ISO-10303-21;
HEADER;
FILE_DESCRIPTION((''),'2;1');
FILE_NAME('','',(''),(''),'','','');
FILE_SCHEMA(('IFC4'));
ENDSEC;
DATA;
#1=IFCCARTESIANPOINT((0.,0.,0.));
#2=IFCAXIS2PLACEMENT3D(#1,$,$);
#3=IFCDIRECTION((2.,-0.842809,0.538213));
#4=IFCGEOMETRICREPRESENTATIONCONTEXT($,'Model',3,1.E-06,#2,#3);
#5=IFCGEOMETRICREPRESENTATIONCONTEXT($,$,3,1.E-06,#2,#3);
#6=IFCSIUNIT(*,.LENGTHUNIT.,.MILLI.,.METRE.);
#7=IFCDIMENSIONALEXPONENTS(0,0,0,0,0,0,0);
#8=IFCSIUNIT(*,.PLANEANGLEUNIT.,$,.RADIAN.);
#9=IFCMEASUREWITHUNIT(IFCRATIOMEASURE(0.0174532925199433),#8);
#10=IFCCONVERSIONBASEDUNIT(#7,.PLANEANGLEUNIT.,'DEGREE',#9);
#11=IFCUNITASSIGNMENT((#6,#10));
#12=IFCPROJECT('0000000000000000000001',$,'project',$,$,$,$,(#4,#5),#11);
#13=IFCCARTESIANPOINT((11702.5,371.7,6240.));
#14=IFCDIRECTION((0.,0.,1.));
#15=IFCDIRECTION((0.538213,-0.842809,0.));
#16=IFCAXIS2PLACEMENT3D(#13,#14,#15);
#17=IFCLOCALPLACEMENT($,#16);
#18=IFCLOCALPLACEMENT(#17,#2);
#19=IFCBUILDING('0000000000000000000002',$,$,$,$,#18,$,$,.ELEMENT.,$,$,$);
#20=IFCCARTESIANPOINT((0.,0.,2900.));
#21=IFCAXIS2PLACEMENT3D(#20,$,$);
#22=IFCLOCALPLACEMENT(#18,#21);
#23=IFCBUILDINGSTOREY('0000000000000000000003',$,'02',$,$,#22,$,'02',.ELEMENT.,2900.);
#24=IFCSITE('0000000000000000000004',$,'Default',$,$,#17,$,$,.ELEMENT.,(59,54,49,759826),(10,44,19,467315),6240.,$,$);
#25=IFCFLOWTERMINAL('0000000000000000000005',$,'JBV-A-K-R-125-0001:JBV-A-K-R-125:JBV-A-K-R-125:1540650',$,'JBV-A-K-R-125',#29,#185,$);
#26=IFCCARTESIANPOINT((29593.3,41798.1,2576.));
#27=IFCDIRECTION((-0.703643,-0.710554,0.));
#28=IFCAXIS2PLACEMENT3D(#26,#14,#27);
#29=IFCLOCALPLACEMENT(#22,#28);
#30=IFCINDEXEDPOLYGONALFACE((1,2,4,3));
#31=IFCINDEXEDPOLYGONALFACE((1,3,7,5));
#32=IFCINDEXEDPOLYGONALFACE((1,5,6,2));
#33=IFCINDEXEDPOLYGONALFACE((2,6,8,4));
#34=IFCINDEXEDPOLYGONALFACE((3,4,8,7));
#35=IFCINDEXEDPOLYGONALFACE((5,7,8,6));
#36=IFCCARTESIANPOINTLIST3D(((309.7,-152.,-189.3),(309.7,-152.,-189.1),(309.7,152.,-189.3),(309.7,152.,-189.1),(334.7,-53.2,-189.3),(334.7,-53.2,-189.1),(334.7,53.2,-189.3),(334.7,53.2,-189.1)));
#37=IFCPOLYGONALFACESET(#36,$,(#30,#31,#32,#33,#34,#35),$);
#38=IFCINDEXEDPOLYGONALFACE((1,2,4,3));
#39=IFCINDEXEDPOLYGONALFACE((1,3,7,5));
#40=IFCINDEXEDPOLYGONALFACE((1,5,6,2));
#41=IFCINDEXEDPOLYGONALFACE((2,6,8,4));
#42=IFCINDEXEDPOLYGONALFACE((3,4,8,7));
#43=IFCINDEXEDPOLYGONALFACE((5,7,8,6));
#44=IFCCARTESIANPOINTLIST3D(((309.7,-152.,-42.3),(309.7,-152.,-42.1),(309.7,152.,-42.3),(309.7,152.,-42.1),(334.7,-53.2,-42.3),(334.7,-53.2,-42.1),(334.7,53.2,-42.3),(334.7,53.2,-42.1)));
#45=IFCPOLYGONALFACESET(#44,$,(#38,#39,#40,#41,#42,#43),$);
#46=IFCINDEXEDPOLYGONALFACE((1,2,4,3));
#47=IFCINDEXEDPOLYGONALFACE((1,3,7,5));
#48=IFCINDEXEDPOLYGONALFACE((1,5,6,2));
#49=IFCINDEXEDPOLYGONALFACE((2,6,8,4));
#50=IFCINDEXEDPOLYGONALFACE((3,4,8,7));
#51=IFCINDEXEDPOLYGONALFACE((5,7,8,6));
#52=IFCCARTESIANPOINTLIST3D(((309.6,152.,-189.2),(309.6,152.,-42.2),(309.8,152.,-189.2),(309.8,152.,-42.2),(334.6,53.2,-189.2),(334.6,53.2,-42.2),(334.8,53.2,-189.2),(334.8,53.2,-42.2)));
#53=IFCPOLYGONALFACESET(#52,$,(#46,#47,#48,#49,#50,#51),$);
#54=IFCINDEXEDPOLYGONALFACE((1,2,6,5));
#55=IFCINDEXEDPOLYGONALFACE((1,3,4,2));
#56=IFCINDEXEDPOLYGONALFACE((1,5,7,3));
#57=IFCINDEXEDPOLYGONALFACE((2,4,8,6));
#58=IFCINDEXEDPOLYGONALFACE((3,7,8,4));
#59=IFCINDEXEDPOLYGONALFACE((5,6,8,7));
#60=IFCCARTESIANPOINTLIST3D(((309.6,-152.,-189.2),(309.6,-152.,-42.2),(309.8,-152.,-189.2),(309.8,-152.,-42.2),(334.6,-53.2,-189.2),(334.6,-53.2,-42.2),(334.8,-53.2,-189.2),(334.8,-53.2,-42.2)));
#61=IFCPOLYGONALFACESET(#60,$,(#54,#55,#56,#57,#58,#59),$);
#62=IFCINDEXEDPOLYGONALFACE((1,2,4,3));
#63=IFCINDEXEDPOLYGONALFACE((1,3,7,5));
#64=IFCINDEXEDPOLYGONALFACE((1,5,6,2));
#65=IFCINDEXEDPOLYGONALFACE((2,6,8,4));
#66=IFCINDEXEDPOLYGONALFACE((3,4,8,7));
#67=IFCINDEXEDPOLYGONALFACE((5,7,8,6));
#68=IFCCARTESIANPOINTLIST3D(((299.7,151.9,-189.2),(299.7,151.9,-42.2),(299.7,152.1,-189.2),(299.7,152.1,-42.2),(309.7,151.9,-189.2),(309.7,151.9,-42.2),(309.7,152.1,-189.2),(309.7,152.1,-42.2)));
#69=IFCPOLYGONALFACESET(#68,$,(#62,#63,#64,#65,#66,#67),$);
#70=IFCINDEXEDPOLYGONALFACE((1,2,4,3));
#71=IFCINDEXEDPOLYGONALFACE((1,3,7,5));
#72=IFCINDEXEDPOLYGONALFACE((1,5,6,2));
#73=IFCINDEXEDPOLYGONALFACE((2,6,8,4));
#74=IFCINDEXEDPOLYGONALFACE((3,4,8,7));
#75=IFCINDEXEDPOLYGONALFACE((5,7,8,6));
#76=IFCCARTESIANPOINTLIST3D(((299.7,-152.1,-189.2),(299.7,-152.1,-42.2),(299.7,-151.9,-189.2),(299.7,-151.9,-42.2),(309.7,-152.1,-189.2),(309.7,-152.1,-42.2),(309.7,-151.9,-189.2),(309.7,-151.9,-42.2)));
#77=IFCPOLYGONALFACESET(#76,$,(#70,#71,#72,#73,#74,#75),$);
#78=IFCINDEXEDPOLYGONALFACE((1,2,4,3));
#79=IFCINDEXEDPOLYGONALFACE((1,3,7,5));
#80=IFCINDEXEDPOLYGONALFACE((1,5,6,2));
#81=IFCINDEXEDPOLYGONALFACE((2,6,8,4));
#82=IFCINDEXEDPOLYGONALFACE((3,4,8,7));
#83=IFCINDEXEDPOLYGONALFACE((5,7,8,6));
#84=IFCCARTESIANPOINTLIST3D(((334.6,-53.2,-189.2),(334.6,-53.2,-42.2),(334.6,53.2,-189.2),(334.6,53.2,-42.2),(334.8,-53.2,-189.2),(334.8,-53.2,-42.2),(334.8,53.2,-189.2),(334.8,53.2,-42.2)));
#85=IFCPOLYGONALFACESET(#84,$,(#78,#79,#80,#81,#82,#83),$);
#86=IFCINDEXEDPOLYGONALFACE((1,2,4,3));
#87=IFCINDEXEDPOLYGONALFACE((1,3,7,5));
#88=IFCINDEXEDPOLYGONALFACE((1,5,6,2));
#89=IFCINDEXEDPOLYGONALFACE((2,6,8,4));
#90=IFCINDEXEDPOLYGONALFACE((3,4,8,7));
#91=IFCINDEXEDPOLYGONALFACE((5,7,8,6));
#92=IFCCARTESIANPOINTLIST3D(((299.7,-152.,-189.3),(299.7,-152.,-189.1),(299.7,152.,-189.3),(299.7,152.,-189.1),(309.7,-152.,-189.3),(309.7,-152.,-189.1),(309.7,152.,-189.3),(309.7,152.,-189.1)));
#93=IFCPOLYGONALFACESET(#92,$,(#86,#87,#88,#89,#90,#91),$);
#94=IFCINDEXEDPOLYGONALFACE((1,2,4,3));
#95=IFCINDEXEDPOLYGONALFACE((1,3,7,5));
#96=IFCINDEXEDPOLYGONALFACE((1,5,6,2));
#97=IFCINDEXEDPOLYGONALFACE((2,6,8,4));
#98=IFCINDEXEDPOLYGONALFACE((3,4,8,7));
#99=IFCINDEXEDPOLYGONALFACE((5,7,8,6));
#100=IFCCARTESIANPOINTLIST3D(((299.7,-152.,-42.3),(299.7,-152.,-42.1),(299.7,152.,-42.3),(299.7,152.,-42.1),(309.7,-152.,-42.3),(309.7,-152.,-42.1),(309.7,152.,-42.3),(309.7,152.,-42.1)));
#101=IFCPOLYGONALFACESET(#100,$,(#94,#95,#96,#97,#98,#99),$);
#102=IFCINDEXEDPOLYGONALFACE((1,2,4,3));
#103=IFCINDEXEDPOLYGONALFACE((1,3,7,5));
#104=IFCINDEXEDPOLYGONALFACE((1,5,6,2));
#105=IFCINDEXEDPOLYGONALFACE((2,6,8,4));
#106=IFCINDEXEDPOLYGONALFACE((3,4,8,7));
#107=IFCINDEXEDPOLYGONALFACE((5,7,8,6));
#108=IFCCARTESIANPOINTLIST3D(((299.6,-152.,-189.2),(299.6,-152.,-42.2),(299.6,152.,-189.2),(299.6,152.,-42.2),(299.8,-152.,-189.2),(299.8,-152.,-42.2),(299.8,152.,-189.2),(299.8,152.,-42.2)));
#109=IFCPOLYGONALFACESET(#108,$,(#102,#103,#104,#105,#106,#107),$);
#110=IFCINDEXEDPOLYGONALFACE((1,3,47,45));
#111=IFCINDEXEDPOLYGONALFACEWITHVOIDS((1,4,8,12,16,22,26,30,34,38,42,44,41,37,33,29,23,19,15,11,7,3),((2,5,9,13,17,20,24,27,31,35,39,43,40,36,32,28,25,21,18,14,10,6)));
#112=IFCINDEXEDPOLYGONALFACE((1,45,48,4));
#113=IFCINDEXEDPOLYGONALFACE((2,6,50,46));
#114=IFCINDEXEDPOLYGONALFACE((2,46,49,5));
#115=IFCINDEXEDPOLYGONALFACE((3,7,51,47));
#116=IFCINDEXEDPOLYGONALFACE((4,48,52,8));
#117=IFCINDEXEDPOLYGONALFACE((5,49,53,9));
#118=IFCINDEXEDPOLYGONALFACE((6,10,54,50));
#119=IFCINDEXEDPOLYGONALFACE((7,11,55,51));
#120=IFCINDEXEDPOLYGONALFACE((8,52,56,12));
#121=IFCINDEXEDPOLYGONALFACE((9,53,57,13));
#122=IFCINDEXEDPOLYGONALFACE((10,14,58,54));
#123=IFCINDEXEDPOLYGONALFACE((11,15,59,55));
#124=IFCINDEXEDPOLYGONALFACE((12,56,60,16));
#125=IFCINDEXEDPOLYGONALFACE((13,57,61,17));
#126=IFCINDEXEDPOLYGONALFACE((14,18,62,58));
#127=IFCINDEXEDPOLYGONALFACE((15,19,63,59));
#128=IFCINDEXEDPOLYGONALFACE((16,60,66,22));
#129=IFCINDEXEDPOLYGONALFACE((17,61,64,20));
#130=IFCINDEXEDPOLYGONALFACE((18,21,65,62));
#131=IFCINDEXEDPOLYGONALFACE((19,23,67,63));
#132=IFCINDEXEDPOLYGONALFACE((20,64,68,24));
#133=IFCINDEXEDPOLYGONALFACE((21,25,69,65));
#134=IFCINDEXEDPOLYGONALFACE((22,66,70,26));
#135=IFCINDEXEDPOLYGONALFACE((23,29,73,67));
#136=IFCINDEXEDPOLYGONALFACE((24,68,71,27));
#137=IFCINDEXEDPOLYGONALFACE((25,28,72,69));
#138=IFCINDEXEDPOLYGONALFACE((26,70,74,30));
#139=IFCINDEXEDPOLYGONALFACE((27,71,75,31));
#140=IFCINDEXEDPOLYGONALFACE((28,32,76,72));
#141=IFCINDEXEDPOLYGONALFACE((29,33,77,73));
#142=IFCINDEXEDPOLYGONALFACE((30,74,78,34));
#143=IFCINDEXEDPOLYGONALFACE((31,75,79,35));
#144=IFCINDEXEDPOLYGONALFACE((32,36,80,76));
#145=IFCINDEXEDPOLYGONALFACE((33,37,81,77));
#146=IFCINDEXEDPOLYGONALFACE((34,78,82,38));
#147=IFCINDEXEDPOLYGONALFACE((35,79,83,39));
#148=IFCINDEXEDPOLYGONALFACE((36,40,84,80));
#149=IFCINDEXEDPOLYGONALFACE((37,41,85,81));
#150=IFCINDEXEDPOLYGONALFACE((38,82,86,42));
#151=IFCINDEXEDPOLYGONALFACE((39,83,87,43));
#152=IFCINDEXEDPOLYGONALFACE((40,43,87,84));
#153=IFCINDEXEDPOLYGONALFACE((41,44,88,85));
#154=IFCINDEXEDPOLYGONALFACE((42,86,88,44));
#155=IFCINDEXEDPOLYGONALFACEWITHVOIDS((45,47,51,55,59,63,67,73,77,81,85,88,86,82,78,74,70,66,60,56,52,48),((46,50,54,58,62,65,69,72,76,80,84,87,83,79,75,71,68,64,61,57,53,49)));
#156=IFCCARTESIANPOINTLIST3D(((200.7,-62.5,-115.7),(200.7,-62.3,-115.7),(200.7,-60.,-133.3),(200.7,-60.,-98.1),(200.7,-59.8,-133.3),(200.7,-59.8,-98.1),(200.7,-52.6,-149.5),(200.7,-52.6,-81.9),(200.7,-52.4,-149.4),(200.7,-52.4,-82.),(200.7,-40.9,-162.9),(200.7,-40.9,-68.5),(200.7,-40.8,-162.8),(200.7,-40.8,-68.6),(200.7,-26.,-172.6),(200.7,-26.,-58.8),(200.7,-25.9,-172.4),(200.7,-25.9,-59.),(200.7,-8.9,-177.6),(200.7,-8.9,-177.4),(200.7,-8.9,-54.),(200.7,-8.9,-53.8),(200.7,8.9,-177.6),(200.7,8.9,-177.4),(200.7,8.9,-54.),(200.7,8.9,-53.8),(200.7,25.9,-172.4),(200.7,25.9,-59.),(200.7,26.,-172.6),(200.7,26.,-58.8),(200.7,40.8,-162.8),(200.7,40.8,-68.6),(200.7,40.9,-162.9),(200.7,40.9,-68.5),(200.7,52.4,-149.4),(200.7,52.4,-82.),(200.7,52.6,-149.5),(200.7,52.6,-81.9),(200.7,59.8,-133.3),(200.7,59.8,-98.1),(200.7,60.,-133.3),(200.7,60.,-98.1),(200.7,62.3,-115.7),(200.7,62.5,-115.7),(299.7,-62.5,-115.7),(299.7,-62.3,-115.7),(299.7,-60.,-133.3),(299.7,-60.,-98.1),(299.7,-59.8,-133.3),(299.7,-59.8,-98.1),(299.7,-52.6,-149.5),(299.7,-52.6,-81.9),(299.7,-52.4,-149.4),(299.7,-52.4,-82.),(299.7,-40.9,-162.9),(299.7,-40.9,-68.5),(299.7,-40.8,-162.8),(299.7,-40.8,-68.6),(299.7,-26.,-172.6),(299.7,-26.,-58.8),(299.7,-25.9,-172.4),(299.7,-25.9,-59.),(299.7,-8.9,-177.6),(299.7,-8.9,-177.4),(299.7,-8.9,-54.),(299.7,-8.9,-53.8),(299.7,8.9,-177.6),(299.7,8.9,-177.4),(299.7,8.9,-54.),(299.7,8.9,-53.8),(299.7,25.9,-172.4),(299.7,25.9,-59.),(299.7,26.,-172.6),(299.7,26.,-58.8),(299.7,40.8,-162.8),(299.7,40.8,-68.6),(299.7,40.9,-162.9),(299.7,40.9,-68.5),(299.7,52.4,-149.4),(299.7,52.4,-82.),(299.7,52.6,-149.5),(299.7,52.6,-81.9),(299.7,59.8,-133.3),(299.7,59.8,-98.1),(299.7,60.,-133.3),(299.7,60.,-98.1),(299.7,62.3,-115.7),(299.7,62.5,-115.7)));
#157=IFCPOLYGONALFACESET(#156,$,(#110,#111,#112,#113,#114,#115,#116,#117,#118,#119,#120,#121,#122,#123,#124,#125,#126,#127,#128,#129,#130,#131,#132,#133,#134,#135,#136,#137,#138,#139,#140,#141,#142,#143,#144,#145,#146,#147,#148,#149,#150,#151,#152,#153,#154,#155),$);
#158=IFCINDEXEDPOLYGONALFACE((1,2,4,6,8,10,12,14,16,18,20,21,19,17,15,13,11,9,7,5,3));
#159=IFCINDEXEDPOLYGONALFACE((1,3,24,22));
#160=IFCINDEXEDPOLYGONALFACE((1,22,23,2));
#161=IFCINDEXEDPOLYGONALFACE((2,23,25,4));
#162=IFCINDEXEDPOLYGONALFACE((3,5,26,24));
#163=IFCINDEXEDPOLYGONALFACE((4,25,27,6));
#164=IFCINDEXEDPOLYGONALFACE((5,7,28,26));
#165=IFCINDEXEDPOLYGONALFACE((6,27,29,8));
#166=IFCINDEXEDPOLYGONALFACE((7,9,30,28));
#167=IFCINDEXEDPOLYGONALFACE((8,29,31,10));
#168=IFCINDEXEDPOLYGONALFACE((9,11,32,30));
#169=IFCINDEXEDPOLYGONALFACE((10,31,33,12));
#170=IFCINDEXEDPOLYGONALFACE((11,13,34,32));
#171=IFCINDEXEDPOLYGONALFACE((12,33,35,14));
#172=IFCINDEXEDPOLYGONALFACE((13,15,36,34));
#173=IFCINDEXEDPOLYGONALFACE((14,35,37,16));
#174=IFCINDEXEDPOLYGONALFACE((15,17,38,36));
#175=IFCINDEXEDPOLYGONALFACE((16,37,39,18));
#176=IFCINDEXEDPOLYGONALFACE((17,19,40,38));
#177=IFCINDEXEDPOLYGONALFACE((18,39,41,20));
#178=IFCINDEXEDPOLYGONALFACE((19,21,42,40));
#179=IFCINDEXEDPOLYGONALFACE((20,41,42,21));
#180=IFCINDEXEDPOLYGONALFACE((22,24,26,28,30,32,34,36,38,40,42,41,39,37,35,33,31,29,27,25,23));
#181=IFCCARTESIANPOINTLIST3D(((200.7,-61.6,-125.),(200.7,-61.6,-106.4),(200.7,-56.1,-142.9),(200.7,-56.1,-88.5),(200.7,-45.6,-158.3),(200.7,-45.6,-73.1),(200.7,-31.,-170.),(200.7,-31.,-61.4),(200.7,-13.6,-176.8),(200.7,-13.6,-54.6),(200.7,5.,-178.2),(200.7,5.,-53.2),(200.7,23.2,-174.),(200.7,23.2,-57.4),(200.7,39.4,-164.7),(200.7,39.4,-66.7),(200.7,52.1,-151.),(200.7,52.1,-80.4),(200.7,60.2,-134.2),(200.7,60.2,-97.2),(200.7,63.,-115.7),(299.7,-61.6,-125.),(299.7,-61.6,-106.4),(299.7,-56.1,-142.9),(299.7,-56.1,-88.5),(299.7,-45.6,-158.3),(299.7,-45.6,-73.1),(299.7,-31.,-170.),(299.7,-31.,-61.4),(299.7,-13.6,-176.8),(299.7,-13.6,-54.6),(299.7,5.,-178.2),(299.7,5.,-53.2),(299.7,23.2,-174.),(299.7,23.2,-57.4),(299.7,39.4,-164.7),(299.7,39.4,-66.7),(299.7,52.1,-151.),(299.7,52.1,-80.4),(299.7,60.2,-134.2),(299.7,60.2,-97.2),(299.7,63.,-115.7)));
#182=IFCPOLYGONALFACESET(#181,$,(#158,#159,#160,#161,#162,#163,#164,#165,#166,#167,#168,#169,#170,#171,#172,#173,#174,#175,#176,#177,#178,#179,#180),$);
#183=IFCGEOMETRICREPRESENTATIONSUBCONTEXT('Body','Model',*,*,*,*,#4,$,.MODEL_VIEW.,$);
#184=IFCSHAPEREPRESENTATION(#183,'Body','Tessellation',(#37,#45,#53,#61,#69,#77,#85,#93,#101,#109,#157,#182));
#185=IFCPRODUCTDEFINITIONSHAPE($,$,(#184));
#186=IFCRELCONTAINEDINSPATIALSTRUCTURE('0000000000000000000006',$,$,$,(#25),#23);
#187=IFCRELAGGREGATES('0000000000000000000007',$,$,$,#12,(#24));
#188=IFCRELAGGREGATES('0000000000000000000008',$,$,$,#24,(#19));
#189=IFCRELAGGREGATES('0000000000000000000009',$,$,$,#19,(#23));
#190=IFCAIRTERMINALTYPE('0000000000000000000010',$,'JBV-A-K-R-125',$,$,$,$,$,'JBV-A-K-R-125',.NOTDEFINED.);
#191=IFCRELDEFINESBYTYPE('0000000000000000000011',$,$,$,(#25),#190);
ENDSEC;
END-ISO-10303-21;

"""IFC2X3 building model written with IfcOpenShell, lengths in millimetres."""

from ifc_helpers import new_model, entity, si_unit, converted_unit, direction, frame, frame_2d, origin, origin_2d_with_axis, place, context, subcontext, project, spatial, polyline, circle_curve, parameter, trimmed, segment, composite_curve, rectangle, circle, outline, extrude, source, transform, mapped, type_object, type_shapes, element, save


model = new_model("IFC2X3")

# Units and contexts
model_context = context("Model", 3, precision=1e-06, world=origin(), true_north=direction((2.0, -0.842809, 0.538213)))
context_of_model = context(None, 3, precision=1e-06, world=origin(), true_north=direction((2.0, -0.842809, 0.538213)))
body_context = subcontext(model_context, "Body", "Model", "MODEL_VIEW")
ifc_project = project(units=[si_unit("LENGTHUNIT", "METRE", prefix="MILLI"), converted_unit("PLANEANGLEUNIT", "DEGREE", entity("IfcRatioMeasure", 0.0174532925199433), si_unit("PLANEANGLEUNIT", "RADIAN"), dimensions=[0, 0, 0, 0, 0, 0, 0])], contexts=[model_context, context_of_model])

# Site, building, storey
site_placement = place(None, frame((11702.5, 371.7, 6240.0), z_axis=(0.0, 0.0, 1.0), x_axis=(0.538213, -0.842809, 0.0)))
site = spatial("IfcSite", under=ifc_project, at=site_placement, Name="Default", CompositionType="ELEMENT", RefLatitude=(59, 54, 49, 759826), RefLongitude=(10, 44, 19, 467315), RefElevation=6240.0)
building_placement = place(site_placement, origin())
building = spatial("IfcBuilding", under=site, at=building_placement, CompositionType="ELEMENT")
storey_placement = place(building_placement, frame((0.0, 0.0, 2900.0)))
storey = spatial("IfcBuildingStorey", under=building, at=storey_placement, Name="02", LongName="02", CompositionType="ELEMENT", Elevation=2900.0)

# Flow terminal
air_terminal_type_1 = type_object("IfcAirTerminalType", Name="JBV-A-K-R-125", ElementType="JBV-A-K-R-125", PredefinedType="NOTDEFINED")
shared_shape_1 = source(origin(), body_context, "Body", "SweptSolid", [
    extrude(outline(polyline([(-152.0, -12.5), (152.0, -12.5), (53.2, 12.5), (-53.2, 12.5), (-152.0, -12.5)])), frame((322.2, 0.0, -189.3), z_axis=(0.0, 0.0, 1.0), x_axis=(0.0, -1.0, 0.0)), (0.0, 0.0, 1.0), 0.2),
    extrude(outline(polyline([(-152.0, -12.5), (152.0, -12.5), (53.2, 12.5), (-53.2, 12.5), (-152.0, -12.5)])), frame((322.2, 0.0, -42.3), z_axis=(0.0, 0.0, 1.0), x_axis=(0.0, -1.0, 0.0)), (0.0, 0.0, 1.0), 0.2),
    extrude(rectangle(XDim=0.2, YDim=101.9, at=frame_2d((0.0, 0.0), x_axis=(1.0, 0.0))), frame((322.2, 102.6, -189.2), z_axis=(0.0, 0.0, 1.0), x_axis=(0.969446, 0.245305, 0.0)), (0.0, 0.0, 1.0), 147.0),
    extrude(rectangle(XDim=0.2, YDim=101.9, at=frame_2d((0.0, 0.0), x_axis=(1.0, 0.0))), frame((322.2, -102.6, -189.2), z_axis=(0.0, 0.0, 1.0), x_axis=(-0.969446, 0.245305, 0.0)), (0.0, 0.0, 1.0), 147.0),
    extrude(rectangle(XDim=0.2, YDim=10.0, at=frame_2d((0.0, 0.0), x_axis=(1.0, 0.0))), frame((304.7, 152.0, -189.2), z_axis=(0.0, 0.0, 1.0), x_axis=(0.0, 1.0, 0.0)), (0.0, 0.0, 1.0), 147.0),
    extrude(rectangle(XDim=0.2, YDim=10.0, at=frame_2d((0.0, 0.0), x_axis=(1.0, 0.0))), frame((304.7, -152.0, -189.2), z_axis=(0.0, 0.0, 1.0), x_axis=(0.0, 1.0, 0.0)), (0.0, 0.0, 1.0), 147.0),
    extrude(rectangle(XDim=0.2, YDim=106.4, at=frame_2d((0.0, 0.0), x_axis=(1.0, 0.0))), frame((334.7, 0.0, -189.2)), (0.0, 0.0, 1.0), 147.0),
    extrude(rectangle(XDim=304.0, YDim=10.0, at=frame_2d((0.0, 0.0), x_axis=(1.0, 0.0))), frame((304.7, 0.0, -189.3), z_axis=(0.0, 0.0, 1.0), x_axis=(0.0, -1.0, 0.0)), (0.0, 0.0, 1.0), 0.2),
    extrude(rectangle(XDim=304.0, YDim=10.0, at=frame_2d((0.0, 0.0), x_axis=(1.0, 0.0))), frame((304.7, 0.0, -42.3), z_axis=(0.0, 0.0, 1.0), x_axis=(0.0, -1.0, 0.0)), (0.0, 0.0, 1.0), 0.2),
    extrude(rectangle(XDim=0.2, YDim=304.0, at=frame_2d((0.0, 0.0), x_axis=(1.0, 0.0))), frame((299.7, 0.0, -189.2)), (0.0, 0.0, 1.0), 147.0),
    extrude(outline(composite_curve([segment(trimmed(circle_curve(origin_2d_with_axis(), 62.5), [parameter(0.0)], [parameter(180.0)], True, "PARAMETER"), True, "CONTINUOUS"), segment(trimmed(circle_curve(origin_2d_with_axis(), 62.5), [parameter(180.0)], [parameter(360.0)], True, "PARAMETER"), True, "CONTINUOUS")], self_intersect=False), holes=[composite_curve([segment(trimmed(circle_curve(origin_2d_with_axis(), 62.3), [parameter(180.0)], [parameter(360.0)], True, "PARAMETER"), False, "CONTINUOUS"), segment(trimmed(circle_curve(origin_2d_with_axis(), 62.3), [parameter(0.0)], [parameter(180.0)], True, "PARAMETER"), False, "CONTINUOUS")], self_intersect=False)]), frame((200.7, 0.0, -115.7), z_axis=(1.0, 0.0, 0.0), x_axis=(0.0, 1.0, 0.0)), (0.0, 0.0, 1.0), 99.0),
    extrude(circle(Radius=62.6, at=frame_2d((0.0, 0.0), x_axis=(1.0, 0.0))), frame((200.7, 0.3, -115.7), z_axis=(1.0, 0.0, 0.0), x_axis=(0.0, 1.0, 0.0)), (0.0, 0.0, 1.0), 99.0),
])
type_shapes(air_terminal_type_1, [shared_shape_1])
for number, where, z_axis, x_axis, name in (
    (1, (29593.3, 41798.1, 2576.0), (0.0, 0.0, 1.0), (-0.703643, -0.710554, 0.0), "JBV-A-K-R-125-0001:JBV-A-K-R-125:JBV-A-K-R-125:1540650"),
):
    element("IfcFlowTerminal", number, at=place(storey_placement, frame(where, z_axis=z_axis, x_axis=x_axis)), inside=storey, type_object=air_terminal_type_1, Name=name, ObjectType="JBV-A-K-R-125", context=body_context, shape_type="MappedRepresentation", body=[
        mapped(shared_shape_1, transform((0.0, 0.0, 0.0), scale=1.0)),
    ])

save(model, "model.ifc")
